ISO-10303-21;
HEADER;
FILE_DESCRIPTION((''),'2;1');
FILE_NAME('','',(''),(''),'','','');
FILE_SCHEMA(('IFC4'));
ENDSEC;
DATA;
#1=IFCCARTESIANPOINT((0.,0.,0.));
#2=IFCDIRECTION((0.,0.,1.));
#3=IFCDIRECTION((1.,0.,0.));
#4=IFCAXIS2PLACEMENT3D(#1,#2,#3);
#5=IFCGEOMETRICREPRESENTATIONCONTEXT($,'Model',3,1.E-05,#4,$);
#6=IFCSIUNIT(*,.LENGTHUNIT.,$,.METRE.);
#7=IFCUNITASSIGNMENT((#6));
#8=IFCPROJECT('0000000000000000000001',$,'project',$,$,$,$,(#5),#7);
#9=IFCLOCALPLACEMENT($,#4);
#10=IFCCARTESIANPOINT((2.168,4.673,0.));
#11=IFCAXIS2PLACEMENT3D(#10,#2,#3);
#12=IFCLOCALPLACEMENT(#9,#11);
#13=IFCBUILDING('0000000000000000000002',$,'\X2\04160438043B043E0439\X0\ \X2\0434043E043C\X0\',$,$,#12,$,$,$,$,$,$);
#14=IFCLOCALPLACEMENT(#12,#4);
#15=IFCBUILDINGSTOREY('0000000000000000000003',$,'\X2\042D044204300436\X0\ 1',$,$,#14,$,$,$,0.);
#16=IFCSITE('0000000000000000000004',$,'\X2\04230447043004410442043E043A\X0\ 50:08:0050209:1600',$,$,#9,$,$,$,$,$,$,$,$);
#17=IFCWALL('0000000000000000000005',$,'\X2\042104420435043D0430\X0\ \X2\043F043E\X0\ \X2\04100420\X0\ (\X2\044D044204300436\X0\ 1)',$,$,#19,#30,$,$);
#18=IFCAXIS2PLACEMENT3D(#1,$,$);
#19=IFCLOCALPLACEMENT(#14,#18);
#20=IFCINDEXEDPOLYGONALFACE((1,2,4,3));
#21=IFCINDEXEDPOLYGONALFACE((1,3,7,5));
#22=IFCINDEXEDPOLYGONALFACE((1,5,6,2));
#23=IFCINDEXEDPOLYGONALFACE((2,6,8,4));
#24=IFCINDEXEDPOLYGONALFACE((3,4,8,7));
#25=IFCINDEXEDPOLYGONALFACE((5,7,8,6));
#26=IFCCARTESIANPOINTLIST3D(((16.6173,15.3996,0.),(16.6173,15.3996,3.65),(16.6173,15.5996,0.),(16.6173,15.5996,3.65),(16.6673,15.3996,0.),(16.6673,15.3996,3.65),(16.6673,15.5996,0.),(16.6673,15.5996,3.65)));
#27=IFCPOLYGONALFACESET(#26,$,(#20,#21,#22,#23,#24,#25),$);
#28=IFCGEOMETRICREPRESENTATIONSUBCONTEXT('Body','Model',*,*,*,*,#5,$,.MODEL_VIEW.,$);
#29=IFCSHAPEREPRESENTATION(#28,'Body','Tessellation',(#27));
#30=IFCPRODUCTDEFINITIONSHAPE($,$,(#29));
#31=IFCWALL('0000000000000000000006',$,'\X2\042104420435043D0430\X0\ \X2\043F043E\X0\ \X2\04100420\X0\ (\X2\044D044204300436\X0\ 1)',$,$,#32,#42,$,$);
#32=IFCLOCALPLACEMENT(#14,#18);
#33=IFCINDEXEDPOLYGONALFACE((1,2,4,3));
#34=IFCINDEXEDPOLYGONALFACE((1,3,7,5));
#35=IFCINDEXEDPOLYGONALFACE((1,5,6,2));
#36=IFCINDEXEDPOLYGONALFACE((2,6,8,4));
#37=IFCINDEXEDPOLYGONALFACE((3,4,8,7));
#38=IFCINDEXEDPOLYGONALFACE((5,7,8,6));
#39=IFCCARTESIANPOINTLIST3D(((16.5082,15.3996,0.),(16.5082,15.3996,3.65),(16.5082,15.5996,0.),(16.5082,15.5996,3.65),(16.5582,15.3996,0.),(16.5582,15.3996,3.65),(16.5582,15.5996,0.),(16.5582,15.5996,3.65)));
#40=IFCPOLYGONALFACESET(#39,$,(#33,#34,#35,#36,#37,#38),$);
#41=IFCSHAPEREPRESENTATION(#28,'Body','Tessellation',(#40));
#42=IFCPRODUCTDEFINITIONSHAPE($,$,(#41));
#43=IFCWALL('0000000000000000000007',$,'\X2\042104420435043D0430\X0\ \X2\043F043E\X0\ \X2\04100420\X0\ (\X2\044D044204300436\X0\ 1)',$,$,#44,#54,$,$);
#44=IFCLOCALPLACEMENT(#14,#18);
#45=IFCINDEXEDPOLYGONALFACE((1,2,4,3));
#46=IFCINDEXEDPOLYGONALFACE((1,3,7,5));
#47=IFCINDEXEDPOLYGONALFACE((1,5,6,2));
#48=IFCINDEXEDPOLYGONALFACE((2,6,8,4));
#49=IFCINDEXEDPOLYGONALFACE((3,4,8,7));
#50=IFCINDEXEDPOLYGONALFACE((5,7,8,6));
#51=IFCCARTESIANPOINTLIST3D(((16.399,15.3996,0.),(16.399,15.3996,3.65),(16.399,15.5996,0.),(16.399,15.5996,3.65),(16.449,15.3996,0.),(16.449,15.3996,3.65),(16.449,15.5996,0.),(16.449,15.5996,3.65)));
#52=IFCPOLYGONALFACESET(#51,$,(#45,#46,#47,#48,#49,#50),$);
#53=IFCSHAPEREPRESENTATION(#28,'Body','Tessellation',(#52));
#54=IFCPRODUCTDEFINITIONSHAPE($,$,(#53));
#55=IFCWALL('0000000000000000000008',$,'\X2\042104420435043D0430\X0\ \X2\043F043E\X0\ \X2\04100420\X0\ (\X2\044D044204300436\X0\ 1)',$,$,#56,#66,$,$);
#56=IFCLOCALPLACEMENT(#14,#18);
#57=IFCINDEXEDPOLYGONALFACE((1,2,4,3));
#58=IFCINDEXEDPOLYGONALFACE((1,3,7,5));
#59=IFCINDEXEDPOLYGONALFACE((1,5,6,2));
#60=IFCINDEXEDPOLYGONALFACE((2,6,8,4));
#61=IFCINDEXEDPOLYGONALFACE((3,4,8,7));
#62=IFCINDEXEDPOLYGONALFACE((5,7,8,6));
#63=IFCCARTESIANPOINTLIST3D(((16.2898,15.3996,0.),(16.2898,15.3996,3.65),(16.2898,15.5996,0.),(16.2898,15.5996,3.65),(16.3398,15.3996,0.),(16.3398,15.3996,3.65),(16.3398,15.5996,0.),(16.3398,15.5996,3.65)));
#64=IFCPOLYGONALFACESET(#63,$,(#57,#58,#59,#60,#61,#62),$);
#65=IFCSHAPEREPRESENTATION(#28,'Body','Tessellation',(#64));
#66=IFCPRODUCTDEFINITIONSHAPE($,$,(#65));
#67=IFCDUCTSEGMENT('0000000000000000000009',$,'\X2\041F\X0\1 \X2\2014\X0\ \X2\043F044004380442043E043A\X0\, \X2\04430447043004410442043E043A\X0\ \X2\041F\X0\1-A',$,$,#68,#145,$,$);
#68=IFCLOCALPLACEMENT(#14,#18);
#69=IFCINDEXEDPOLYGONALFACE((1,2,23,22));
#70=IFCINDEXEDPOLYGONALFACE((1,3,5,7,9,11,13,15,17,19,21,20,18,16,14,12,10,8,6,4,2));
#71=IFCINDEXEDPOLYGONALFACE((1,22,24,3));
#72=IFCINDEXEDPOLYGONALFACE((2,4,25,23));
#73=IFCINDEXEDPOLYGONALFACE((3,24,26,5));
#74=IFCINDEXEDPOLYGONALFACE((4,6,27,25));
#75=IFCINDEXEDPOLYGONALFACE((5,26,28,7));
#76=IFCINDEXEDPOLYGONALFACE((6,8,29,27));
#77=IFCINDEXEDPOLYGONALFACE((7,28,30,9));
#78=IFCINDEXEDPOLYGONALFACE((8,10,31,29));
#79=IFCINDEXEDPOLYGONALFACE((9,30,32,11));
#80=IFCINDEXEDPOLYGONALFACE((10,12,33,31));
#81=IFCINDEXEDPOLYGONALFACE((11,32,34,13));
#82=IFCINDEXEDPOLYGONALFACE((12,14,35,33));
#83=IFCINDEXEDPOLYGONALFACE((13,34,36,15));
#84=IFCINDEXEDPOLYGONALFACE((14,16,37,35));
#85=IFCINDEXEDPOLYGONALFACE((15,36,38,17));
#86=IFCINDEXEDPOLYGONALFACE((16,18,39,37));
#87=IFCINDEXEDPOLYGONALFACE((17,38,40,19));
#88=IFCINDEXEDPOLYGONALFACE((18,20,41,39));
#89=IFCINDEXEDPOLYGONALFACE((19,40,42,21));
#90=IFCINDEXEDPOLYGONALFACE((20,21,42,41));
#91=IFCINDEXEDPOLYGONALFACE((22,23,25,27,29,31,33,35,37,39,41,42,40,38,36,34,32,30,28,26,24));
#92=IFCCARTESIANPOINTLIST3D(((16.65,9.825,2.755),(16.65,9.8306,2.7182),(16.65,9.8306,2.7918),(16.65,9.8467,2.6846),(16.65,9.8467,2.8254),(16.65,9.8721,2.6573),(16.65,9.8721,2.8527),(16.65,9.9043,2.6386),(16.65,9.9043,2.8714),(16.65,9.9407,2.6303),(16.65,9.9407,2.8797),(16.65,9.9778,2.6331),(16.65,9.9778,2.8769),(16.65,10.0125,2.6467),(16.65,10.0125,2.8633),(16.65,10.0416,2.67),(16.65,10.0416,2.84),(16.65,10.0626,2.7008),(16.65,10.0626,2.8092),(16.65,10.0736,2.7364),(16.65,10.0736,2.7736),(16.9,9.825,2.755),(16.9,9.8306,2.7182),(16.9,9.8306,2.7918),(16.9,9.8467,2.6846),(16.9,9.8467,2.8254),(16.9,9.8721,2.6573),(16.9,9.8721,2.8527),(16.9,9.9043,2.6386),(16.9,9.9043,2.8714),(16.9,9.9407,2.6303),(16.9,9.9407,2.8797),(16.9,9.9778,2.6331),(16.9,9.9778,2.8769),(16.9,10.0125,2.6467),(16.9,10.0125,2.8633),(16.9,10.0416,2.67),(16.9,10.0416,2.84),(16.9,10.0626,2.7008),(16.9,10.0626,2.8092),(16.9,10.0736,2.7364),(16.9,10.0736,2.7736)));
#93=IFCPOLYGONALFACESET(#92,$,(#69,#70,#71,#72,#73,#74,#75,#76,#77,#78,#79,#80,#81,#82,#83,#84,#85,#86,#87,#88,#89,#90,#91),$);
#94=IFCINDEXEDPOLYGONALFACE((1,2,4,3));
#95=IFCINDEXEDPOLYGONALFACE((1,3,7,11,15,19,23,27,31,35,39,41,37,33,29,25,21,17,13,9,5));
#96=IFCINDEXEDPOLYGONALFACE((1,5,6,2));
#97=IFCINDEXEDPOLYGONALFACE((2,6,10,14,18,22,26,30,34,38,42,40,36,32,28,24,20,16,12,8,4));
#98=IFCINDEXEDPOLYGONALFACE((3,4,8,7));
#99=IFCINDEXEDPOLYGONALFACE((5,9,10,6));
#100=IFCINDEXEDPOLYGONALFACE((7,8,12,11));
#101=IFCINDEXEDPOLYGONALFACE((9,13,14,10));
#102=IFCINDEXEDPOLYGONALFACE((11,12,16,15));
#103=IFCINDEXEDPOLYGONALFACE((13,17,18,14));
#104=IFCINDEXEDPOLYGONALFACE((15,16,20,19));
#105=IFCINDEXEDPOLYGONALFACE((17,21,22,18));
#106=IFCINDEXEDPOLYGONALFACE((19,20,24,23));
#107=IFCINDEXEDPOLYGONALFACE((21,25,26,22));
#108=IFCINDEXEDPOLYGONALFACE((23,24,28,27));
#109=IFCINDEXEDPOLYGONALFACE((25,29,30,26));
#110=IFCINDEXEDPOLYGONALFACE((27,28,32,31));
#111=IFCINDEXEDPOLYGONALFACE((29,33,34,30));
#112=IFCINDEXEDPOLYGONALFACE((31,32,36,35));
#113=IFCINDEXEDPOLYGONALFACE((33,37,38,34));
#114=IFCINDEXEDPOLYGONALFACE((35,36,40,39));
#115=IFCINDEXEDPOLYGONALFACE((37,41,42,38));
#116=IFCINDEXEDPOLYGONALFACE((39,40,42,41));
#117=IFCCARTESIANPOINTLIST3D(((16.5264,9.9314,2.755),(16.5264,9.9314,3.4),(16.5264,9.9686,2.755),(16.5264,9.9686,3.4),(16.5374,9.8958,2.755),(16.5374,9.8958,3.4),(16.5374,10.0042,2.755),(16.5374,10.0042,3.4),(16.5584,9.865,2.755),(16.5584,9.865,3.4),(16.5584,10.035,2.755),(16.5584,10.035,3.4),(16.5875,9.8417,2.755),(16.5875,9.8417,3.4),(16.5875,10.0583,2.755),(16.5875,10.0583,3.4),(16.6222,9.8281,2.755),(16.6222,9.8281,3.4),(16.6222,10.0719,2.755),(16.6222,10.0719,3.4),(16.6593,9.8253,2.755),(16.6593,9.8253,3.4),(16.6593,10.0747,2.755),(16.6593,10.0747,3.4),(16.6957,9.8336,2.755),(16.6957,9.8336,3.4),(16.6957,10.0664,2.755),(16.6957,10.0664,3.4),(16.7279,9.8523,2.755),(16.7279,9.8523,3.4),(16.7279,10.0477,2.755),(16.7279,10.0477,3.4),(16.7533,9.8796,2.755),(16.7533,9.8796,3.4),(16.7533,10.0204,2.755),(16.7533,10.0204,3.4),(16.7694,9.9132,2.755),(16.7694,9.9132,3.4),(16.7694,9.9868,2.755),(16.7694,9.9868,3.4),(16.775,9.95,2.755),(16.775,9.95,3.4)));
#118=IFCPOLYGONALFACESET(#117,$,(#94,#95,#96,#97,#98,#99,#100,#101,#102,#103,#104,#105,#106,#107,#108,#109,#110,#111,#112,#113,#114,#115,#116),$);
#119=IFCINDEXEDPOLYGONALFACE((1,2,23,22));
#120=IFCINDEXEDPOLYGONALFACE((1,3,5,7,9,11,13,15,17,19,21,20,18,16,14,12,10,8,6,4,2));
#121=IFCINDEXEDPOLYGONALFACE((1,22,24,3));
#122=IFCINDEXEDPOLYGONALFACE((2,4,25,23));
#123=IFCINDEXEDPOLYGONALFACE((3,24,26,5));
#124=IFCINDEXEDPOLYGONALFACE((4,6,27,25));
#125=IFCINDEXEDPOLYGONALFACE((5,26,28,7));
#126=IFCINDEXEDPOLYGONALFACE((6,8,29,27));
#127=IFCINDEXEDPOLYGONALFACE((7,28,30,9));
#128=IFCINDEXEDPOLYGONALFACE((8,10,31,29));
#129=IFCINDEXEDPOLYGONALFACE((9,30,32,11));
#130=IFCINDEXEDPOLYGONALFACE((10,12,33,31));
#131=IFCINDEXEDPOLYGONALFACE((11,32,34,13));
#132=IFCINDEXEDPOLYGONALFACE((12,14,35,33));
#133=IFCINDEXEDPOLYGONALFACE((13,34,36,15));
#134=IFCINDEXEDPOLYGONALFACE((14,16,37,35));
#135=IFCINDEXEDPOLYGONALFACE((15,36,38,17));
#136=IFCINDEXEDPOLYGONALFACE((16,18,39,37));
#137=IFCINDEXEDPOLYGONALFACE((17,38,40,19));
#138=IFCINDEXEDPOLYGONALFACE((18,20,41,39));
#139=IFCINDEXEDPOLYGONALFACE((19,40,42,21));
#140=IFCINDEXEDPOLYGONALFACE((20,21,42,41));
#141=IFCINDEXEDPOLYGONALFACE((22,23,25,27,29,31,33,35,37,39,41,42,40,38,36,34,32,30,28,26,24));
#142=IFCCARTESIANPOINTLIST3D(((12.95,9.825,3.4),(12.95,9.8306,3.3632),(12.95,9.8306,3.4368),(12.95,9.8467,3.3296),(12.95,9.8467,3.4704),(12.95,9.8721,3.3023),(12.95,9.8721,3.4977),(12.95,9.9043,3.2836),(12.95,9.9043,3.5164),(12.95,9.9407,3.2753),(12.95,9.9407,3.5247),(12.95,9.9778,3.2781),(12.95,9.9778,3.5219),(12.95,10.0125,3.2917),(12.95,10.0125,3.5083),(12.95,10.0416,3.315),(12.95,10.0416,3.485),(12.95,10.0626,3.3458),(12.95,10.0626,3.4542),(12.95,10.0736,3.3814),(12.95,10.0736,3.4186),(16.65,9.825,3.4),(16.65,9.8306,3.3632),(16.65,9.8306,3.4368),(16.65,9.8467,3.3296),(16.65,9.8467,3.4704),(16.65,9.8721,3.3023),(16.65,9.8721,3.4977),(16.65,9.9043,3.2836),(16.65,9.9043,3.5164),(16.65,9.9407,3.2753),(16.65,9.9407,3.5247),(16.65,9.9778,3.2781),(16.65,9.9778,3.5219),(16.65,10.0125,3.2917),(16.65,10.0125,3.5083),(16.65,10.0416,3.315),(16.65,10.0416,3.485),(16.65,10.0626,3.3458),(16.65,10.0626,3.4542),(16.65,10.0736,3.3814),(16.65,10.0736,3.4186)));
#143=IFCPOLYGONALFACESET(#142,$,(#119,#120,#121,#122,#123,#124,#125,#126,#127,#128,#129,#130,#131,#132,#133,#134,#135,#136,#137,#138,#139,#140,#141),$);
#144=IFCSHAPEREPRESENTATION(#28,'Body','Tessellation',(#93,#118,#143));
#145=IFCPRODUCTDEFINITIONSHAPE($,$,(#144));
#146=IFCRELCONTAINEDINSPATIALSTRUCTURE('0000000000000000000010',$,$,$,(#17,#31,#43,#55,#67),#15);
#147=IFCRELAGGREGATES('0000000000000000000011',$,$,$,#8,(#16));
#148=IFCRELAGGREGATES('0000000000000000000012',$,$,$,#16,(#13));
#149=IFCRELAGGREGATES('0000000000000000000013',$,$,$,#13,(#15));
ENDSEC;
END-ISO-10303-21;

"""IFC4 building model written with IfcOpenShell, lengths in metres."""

from ifc_helpers import new_model, si_unit, frame, origin_with_axes, origin_2d, place, context, subcontext, project, spatial, polyline, circle, outline, extrude, element, save


model = new_model("IFC4")

# Units and contexts
model_context = context("Model", 3, precision=1e-05, world=origin_with_axes())
body_context = subcontext(model_context, "Body", "Model", "MODEL_VIEW")
ifc_project = project(units=[si_unit("LENGTHUNIT", "METRE")], contexts=[model_context])

# Site, building, storey
site_placement = place(None, origin_with_axes())
site = spatial("IfcSite", under=ifc_project, at=site_placement, Name="Участок 50:08:0050209:1600")
building_placement = place(site_placement, frame((2.168, 4.673, 0.0), z_axis=(0.0, 0.0, 1.0), x_axis=(1.0, 0.0, 0.0)))
building = spatial("IfcBuilding", under=site, at=building_placement, Name="Жилой дом")
storey_placement = place(building_placement, origin_with_axes())
storey = spatial("IfcBuildingStorey", under=building, at=storey_placement, Name="Этаж 1", Elevation=0.0)

# Walls
wall_1_placement = place(storey_placement, origin_with_axes())
element("IfcWall", 1, at=wall_1_placement, inside=storey, Name="Стена по АР (этаж 1)", context=body_context, shape_type="SweptSolid", body=[
    extrude(outline(polyline([(16.6673, 15.3996), (16.6173, 15.3996), (16.6173, 15.5996), (16.6673, 15.5996), (16.6673, 15.3996)])), origin_with_axes(), (0.0, 0.0, 1.0), 3.65),
])
wall_2_placement = place(storey_placement, origin_with_axes())
element("IfcWall", 2, at=wall_2_placement, inside=storey, Name="Стена по АР (этаж 1)", context=body_context, shape_type="SweptSolid", body=[
    extrude(outline(polyline([(16.5582, 15.3996), (16.5082, 15.3996), (16.5082, 15.5996), (16.5582, 15.5996), (16.5582, 15.3996)])), origin_with_axes(), (0.0, 0.0, 1.0), 3.65),
])
wall_3_placement = place(storey_placement, origin_with_axes())
element("IfcWall", 3, at=wall_3_placement, inside=storey, Name="Стена по АР (этаж 1)", context=body_context, shape_type="SweptSolid", body=[
    extrude(outline(polyline([(16.449, 15.5996), (16.449, 15.3996), (16.399, 15.3996), (16.399, 15.5996), (16.449, 15.5996)])), origin_with_axes(), (0.0, 0.0, 1.0), 3.65),
])
wall_4_placement = place(storey_placement, origin_with_axes())
element("IfcWall", 4, at=wall_4_placement, inside=storey, Name="Стена по АР (этаж 1)", context=body_context, shape_type="SweptSolid", body=[
    extrude(outline(polyline([(16.3398, 15.3996), (16.2898, 15.3996), (16.2898, 15.5996), (16.3398, 15.5996), (16.3398, 15.3996)])), origin_with_axes(), (0.0, 0.0, 1.0), 3.65),
])

# Duct segment
duct_segment_1_placement = place(storey_placement, origin_with_axes())
element("IfcDuctSegment", 5, at=duct_segment_1_placement, inside=storey, Name="П1 — приток, участок П1-A", context=body_context, shape_type="SweptSolid", body=[
    extrude(circle(Radius=0.125, at=origin_2d()), frame((16.9, 9.95, 2.755), z_axis=(-1.0, 0.0, 0.0), x_axis=(0.0, -1.0, 0.0)), (0.0, 0.0, 1.0), 0.25),
    extrude(circle(Radius=0.125, at=origin_2d()), frame((16.65, 9.95, 2.755), z_axis=(0.0, 0.0, 1.0), x_axis=(1.0, 0.0, 0.0)), (0.0, 0.0, 1.0), 0.645),
    extrude(circle(Radius=0.125, at=origin_2d()), frame((16.65, 9.95, 3.4), z_axis=(-1.0, 0.0, 0.0), x_axis=(0.0, -1.0, 0.0)), (0.0, 0.0, 1.0), 3.7),
])

save(model, "model.ifc")
